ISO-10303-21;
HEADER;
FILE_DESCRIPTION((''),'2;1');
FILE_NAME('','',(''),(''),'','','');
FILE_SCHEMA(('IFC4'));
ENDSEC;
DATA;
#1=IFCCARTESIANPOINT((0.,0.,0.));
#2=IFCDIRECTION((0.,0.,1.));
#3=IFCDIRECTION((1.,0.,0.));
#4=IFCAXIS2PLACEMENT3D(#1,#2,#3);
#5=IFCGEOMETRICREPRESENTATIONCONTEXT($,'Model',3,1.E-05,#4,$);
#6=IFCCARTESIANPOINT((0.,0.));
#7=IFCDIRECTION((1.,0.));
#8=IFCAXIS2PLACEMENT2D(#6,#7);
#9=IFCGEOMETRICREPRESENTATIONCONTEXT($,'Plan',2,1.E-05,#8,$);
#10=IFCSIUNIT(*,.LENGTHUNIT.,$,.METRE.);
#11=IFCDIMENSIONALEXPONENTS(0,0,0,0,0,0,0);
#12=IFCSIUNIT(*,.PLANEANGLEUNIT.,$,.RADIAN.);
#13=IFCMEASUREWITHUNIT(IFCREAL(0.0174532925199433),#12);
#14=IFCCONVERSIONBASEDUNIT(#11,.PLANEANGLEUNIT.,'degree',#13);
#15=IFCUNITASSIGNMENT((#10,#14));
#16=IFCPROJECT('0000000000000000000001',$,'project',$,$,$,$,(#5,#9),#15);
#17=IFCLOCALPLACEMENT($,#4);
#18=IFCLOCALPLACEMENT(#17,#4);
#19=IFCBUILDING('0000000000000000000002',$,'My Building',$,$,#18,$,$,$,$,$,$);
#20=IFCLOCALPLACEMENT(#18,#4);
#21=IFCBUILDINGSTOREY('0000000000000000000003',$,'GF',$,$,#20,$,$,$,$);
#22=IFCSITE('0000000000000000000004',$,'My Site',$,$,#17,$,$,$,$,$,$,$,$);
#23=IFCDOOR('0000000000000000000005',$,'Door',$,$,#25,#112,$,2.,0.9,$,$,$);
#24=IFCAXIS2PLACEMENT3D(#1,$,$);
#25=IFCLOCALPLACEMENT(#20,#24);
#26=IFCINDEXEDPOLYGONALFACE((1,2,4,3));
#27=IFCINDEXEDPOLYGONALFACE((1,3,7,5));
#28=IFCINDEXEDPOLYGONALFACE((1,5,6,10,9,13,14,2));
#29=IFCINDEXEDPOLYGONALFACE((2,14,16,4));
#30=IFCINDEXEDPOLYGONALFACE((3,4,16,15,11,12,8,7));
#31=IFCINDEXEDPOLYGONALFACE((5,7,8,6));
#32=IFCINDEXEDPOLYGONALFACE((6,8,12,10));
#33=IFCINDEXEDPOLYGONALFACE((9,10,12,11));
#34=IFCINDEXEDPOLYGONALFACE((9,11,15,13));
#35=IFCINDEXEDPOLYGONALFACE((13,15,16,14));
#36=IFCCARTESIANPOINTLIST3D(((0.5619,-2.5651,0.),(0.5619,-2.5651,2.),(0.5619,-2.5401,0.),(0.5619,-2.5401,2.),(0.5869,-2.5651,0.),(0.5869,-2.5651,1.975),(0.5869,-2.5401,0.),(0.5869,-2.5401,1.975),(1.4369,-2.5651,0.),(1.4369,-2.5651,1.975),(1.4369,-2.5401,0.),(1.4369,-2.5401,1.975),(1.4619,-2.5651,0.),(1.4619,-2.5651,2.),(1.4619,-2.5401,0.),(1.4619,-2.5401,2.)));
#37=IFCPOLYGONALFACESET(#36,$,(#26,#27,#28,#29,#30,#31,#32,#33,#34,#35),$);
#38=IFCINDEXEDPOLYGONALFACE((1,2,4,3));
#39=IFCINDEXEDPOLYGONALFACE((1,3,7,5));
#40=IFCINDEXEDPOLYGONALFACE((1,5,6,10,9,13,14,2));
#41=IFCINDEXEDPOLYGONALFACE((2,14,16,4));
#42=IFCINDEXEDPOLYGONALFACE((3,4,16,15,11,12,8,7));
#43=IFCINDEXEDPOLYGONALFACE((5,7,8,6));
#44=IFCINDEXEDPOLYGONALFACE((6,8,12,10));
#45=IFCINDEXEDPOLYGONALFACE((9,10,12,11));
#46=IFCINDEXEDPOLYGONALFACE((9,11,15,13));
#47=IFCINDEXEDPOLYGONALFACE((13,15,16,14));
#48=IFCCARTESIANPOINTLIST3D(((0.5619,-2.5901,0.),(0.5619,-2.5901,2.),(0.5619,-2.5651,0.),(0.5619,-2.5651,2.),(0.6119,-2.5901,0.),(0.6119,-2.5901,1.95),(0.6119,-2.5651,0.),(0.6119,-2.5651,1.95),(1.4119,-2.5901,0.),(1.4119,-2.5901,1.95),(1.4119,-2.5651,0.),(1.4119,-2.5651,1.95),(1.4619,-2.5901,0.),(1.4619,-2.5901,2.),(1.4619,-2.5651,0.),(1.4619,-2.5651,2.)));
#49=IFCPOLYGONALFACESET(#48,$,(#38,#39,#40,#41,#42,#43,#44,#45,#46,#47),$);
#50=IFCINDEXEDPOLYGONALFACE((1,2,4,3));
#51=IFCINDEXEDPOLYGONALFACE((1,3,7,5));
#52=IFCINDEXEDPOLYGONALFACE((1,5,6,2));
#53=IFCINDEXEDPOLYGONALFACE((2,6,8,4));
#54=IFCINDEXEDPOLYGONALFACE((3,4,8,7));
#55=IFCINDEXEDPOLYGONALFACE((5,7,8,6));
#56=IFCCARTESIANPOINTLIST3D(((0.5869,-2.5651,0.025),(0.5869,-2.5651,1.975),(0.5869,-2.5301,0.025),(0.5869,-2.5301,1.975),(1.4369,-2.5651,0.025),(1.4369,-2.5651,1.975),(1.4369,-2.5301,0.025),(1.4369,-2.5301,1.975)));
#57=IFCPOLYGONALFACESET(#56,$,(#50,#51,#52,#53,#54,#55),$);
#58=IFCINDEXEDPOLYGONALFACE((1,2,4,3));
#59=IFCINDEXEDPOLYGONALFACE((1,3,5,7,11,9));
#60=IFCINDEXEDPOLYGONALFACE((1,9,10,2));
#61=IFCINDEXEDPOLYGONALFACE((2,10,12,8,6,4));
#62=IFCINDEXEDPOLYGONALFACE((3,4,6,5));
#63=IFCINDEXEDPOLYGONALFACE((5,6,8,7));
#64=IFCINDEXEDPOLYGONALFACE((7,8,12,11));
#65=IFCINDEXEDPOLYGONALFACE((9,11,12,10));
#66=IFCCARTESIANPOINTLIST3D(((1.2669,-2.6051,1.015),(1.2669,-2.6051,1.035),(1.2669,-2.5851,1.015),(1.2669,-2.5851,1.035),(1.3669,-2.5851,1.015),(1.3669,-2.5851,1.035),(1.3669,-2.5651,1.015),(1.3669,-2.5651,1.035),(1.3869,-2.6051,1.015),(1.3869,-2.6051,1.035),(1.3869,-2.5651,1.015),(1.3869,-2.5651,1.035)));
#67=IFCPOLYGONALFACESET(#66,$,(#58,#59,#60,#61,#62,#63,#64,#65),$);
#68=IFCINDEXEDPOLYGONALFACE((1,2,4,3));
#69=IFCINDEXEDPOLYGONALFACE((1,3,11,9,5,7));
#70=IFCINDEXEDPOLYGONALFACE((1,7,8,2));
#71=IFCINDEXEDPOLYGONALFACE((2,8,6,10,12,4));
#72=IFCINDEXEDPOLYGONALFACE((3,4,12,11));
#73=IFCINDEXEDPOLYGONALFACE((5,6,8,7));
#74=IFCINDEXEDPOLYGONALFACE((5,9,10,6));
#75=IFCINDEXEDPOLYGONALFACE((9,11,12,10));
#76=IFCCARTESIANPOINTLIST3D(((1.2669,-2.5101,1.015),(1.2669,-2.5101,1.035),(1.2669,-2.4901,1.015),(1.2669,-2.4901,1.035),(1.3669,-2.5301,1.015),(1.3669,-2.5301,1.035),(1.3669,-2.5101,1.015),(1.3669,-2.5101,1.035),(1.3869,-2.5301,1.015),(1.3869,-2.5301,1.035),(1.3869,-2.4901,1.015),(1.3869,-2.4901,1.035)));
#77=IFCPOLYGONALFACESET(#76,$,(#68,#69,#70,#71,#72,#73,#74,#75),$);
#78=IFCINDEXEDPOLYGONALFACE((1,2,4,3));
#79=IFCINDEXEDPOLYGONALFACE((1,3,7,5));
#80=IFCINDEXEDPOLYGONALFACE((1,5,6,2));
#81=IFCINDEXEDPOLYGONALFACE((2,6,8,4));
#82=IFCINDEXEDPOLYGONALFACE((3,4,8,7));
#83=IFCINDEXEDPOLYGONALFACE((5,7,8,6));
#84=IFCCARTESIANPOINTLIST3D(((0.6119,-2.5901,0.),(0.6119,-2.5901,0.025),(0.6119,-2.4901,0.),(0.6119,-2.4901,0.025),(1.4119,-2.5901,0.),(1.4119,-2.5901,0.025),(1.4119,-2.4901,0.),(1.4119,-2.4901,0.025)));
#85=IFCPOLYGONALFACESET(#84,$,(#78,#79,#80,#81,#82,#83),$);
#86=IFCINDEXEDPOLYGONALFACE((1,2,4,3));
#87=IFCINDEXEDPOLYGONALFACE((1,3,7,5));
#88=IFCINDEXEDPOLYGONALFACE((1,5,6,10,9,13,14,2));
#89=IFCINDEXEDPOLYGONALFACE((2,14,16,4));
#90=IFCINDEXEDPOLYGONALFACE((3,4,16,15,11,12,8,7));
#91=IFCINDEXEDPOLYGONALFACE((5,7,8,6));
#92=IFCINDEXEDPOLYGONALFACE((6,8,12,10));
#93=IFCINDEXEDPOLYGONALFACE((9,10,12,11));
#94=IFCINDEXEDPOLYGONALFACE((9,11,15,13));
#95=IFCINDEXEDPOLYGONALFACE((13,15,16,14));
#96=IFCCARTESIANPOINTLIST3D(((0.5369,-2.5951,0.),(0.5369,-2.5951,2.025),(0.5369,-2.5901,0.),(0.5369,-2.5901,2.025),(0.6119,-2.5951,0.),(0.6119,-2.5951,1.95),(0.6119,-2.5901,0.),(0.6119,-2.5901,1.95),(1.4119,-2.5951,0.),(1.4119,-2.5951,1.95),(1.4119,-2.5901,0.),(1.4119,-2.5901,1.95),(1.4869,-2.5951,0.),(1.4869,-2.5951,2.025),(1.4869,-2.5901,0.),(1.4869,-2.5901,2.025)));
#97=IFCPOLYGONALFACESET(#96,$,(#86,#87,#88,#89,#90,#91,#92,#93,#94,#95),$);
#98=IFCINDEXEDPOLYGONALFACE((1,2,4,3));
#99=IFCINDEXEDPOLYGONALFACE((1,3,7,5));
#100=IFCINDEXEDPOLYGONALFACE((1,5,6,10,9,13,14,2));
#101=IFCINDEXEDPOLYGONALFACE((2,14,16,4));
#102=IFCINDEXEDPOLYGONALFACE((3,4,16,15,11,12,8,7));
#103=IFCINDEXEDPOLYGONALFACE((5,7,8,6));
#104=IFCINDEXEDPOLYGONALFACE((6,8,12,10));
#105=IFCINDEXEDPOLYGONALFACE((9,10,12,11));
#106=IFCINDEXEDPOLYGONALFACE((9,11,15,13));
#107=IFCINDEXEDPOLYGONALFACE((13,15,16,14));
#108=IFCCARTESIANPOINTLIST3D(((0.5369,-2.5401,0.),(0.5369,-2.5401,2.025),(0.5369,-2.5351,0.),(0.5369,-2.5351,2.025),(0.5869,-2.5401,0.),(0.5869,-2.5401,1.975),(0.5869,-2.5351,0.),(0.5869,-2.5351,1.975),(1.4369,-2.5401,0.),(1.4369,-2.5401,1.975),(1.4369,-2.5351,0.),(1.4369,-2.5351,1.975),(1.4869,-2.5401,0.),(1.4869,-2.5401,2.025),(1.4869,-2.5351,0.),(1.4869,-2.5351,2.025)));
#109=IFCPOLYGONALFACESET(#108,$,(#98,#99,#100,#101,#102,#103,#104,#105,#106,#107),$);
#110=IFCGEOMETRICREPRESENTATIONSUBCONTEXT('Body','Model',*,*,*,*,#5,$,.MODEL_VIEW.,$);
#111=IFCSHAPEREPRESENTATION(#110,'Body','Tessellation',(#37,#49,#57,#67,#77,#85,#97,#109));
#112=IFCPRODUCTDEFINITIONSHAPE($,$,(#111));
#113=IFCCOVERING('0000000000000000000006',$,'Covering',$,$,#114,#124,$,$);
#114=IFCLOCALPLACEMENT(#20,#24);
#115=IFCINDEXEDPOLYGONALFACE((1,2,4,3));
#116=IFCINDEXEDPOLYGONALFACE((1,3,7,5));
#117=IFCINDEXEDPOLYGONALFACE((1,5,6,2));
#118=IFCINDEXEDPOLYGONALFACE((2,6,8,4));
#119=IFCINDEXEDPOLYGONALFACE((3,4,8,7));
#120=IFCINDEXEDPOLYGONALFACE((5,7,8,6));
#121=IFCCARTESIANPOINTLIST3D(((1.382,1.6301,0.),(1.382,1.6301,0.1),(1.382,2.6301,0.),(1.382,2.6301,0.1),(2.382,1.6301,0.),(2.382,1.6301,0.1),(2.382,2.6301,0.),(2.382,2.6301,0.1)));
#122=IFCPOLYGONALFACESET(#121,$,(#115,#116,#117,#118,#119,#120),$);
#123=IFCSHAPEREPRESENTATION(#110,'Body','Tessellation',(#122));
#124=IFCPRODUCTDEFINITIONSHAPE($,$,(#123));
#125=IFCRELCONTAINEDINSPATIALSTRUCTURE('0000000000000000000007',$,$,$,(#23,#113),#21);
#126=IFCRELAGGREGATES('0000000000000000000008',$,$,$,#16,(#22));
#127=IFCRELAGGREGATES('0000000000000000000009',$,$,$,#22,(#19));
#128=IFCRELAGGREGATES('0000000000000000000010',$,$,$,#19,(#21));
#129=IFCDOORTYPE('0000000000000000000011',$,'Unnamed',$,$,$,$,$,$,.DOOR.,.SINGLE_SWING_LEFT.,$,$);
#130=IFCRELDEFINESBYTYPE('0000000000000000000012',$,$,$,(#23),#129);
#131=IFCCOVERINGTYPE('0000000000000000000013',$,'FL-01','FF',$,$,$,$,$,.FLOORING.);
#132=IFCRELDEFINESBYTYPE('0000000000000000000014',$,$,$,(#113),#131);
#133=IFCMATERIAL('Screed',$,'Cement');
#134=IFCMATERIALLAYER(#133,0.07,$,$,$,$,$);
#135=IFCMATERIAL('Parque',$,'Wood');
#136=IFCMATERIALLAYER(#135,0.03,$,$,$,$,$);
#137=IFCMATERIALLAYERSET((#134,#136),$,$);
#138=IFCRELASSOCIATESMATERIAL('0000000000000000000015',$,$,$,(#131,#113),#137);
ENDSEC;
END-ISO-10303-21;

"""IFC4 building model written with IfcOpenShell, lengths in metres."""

from ifc_helpers import new_model, entity, si_unit, converted_unit, frame, origin_with_axes, origin_2d_with_axis, place, context, subcontext, project, spatial, line, indexed_curve, outline, extrude, shape, source, transform, mapped, material, layer, layer_set, layer_usage, type_object, type_shapes, element, save


model = new_model("IFC4")

# Units and contexts
model_context = context("Model", 3, precision=1e-05, world=origin_with_axes())
plan_context = context("Plan", 2, precision=1e-05, world=origin_2d_with_axis())
body_context_1 = subcontext(model_context, "Body", "Model", "MODEL_VIEW")
body_context_2 = subcontext(plan_context, "Body", "Plan", "PLAN_VIEW")
ifc_project = project(units=[si_unit("LENGTHUNIT", "METRE"), converted_unit("PLANEANGLEUNIT", "degree", entity("IfcReal", 0.0174532925199433), si_unit("PLANEANGLEUNIT", "RADIAN"), dimensions=[0, 0, 0, 0, 0, 0, 0])], contexts=[model_context, plan_context])

# Site, building, storey
site_placement = place(None, origin_with_axes())
site = spatial("IfcSite", under=ifc_project, at=site_placement, Name="My Site")
building_placement = place(site_placement, origin_with_axes())
building = spatial("IfcBuilding", under=site, at=building_placement, Name="My Building")
storey_placement = place(building_placement, origin_with_axes())
storey = spatial("IfcBuildingStorey", under=building, at=storey_placement, Name="GF")

# Shared definitions
door_type = type_object("IfcDoorType", Name="Unnamed", OperationType="SINGLE_SWING_LEFT", PredefinedType="DOOR")
shared_shape_1 = source(origin_with_axes(), body_context_1, "Body", "SweptSolid", [
    extrude(outline(indexed_curve([(0.0, 0.0), (0.0, 2.0), (0.9, 2.0), (0.9, 0.0), (0.875, 0.0), (0.875, 1.975), (0.025, 1.975), (0.025, 0.0)], segments=[line(1, 2, 3, 4, 5, 6, 7, 8, 1)])), frame((0.0, 0.025, 0.0), z_axis=(0.0, -1.0, 0.0), x_axis=(1.0, 0.0, 0.0)), (0.0, 0.0, -1.0), 0.025),
    extrude(outline(indexed_curve([(0.0, 0.0), (0.0, 2.0), (0.9, 2.0), (0.9, 0.0), (0.85, 0.0), (0.85, 1.95), (0.05, 1.95), (0.05, 0.0)], segments=[line(1, 2, 3, 4, 5, 6, 7, 8, 1)])), frame((0.0, 0.0, 0.0), z_axis=(0.0, -1.0, 0.0), x_axis=(1.0, 0.0, 0.0)), (0.0, 0.0, -1.0), 0.025),
    extrude(outline(indexed_curve([(0.0, 0.0), (0.85, 0.0), (0.85, 0.035), (0.0, 0.035)], segments=[line(1, 2, 3, 4, 1)])), frame((0.025, 0.025, 0.025), z_axis=(0.0, 0.0, 1.0), x_axis=(1.0, 0.0, 0.0)), (0.0, 0.0, 1.0), 1.95),
    extrude(outline(indexed_curve([(0.0, 0.0), (0.0, -0.04), (-0.12, -0.04), (-0.12, -0.02), (-0.02, -0.02), (-0.02, 0.0)], segments=[line(1, 2, 3, 4, 5, 6, 1)])), frame((0.825, 0.025, 1.015), z_axis=(0.0, 0.0, 1.0), x_axis=(1.0, 0.0, 0.0)), (0.0, 0.0, 1.0), 0.02),
    extrude(outline(indexed_curve([(0.0, 0.0), (0.0, 0.04), (-0.12, 0.04), (-0.12, 0.02), (-0.02, 0.02), (-0.02, 0.0)], segments=[line(1, 2, 3, 4, 5, 6, 1)])), frame((0.825, 0.06, 1.015), z_axis=(0.0, 0.0, 1.0), x_axis=(1.0, 0.0, 0.0)), (0.0, 0.0, 1.0), 0.02),
    extrude(outline(indexed_curve([(0.0, 0.0), (0.8, 0.0), (0.8, 0.1), (0.0, 0.1)], segments=[line(1, 2, 3, 4, 1)])), frame((0.05, 0.0, 0.0), z_axis=(0.0, 0.0, 1.0), x_axis=(1.0, 0.0, 0.0)), (0.0, 0.0, 1.0), 0.025),
    extrude(outline(indexed_curve([(0.0, 0.0), (0.0, 2.025), (0.95, 2.025), (0.95, 0.0), (0.875, 0.0), (0.875, 1.95), (0.075, 1.95), (0.075, 0.0)], segments=[line(1, 2, 3, 4, 5, 6, 7, 8, 1)])), frame((-0.025, -0.005, 0.0), z_axis=(0.0, -1.0, 0.0), x_axis=(1.0, 0.0, 0.0)), (0.0, 0.0, -1.0), 0.005),
    extrude(outline(indexed_curve([(0.0, 0.0), (0.0, 2.025), (0.95, 2.025), (0.95, 0.0), (0.9, 0.0), (0.9, 1.975), (0.05, 1.975), (0.05, 0.0)], segments=[line(1, 2, 3, 4, 5, 6, 7, 8, 1)])), frame((-0.025, 0.05, 0.0), z_axis=(0.0, -1.0, 0.0), x_axis=(1.0, 0.0, 0.0)), (0.0, 0.0, -1.0), 0.005),
])
shared_shape_2 = source(origin_with_axes(), body_context_2, "Body", "Curve2D", [
    entity("IfcIndexedPolyCurve", entity("IfcCartesianPointList2D", [[0.0, 0.0], [0.0, 0.05], [0.025, 0.05], [0.025, 0.025], [0.05, 0.025], [0.05, 0.0]]), [entity("IfcLineIndex", [1, 2, 3, 4, 5, 6, 1])]),
    entity("IfcIndexedPolyCurve", entity("IfcCartesianPointList2D", [[0.9, 0.0], [0.9, 0.05], [0.875, 0.05], [0.875, 0.025], [0.85, 0.025], [0.85, 0.0]]), [entity("IfcLineIndex", [1, 2, 3, 4, 5, 6, 1])]),
    entity("IfcTrimmedCurve", entity("IfcEllipse", entity("IfcAxis2Placement2D", entity("IfcCartesianPoint", [0.06, 0.05]), entity("IfcDirection", [1.0, 0.0])), 0.815, 0.85), [entity("IfcCartesianPoint", [0.875, 0.05])], [entity("IfcCartesianPoint", [0.06, 0.9])], True, "CARTESIAN"),
    entity("IfcIndexedPolyCurve", entity("IfcCartesianPointList2D", [[0.025, 0.05], [0.06, 0.05], [0.06, 0.9], [0.025, 0.9]]), [entity("IfcLineIndex", [1, 2, 3, 4, 1])]),
])
type_shapes(door_type, [shared_shape_1, shared_shape_2])

# Door
door_1_placement = place(storey_placement, frame((0.5619, -2.5901, 0.0), z_axis=(0.0, 0.0, 1.0), x_axis=(1.0, 0.0, 0.0)))
element("IfcDoor", 1, at=door_1_placement, inside=storey, type_object=door_type, Name="Door", OverallHeight=2.0, OverallWidth=0.9, shapes=[
    shape(body_context_1, "Body", "MappedRepresentation", [mapped(shared_shape_1, transform((0.0, 0.0, 0.0), x_axis=(1.0, 0.0, 0.0), y_axis=(0.0, 1.0, 0.0), z_axis=(0.0, 0.0, 1.0), scale=1.0))]),
    shape(body_context_2, "Body", "MappedRepresentation", [mapped(shared_shape_2, transform((0.0, 0.0, 0.0), x_axis=(1.0, 0.0, 0.0), y_axis=(0.0, 1.0, 0.0), z_axis=(0.0, 0.0, 1.0), scale=1.0))]),
])

# Covering
ifc_material_1 = material(Name="Screed", Category="Cement")
ifc_layer_1 = layer(ifc_material_1, 0.07)
ifc_material_2 = material(Name="Parque", Category="Wood")
ifc_layer_2 = layer(ifc_material_2, 0.03)
ifc_layer_set_1 = layer_set([ifc_layer_1, ifc_layer_2])
ifc_layer_usage_1 = layer_usage(ifc_layer_set_1, "AXIS3", "POSITIVE", 0.0)
covering_type = type_object("IfcCoveringType", Name="FL-01", Description="FF", PredefinedType="FLOORING", material=ifc_layer_set_1)
covering_placement = place(storey_placement, frame((1.382, 1.6301, 0.0), z_axis=(0.0, 0.0, 1.0), x_axis=(1.0, 0.0, 0.0)))
element("IfcCovering", 2, at=covering_placement, inside=storey, type_object=covering_type, material=ifc_layer_usage_1, Name="Covering", context=body_context_1, shape_type="SweptSolid", body=[
    extrude(outline(indexed_curve([(0.0, 0.0), (1.0, 0.0), (1.0, 1.0), (0.0, 1.0), (0.0, 0.0)])), None, (0.0, 0.0, 1.0), 0.1),
])

save(model, "model.ifc")
